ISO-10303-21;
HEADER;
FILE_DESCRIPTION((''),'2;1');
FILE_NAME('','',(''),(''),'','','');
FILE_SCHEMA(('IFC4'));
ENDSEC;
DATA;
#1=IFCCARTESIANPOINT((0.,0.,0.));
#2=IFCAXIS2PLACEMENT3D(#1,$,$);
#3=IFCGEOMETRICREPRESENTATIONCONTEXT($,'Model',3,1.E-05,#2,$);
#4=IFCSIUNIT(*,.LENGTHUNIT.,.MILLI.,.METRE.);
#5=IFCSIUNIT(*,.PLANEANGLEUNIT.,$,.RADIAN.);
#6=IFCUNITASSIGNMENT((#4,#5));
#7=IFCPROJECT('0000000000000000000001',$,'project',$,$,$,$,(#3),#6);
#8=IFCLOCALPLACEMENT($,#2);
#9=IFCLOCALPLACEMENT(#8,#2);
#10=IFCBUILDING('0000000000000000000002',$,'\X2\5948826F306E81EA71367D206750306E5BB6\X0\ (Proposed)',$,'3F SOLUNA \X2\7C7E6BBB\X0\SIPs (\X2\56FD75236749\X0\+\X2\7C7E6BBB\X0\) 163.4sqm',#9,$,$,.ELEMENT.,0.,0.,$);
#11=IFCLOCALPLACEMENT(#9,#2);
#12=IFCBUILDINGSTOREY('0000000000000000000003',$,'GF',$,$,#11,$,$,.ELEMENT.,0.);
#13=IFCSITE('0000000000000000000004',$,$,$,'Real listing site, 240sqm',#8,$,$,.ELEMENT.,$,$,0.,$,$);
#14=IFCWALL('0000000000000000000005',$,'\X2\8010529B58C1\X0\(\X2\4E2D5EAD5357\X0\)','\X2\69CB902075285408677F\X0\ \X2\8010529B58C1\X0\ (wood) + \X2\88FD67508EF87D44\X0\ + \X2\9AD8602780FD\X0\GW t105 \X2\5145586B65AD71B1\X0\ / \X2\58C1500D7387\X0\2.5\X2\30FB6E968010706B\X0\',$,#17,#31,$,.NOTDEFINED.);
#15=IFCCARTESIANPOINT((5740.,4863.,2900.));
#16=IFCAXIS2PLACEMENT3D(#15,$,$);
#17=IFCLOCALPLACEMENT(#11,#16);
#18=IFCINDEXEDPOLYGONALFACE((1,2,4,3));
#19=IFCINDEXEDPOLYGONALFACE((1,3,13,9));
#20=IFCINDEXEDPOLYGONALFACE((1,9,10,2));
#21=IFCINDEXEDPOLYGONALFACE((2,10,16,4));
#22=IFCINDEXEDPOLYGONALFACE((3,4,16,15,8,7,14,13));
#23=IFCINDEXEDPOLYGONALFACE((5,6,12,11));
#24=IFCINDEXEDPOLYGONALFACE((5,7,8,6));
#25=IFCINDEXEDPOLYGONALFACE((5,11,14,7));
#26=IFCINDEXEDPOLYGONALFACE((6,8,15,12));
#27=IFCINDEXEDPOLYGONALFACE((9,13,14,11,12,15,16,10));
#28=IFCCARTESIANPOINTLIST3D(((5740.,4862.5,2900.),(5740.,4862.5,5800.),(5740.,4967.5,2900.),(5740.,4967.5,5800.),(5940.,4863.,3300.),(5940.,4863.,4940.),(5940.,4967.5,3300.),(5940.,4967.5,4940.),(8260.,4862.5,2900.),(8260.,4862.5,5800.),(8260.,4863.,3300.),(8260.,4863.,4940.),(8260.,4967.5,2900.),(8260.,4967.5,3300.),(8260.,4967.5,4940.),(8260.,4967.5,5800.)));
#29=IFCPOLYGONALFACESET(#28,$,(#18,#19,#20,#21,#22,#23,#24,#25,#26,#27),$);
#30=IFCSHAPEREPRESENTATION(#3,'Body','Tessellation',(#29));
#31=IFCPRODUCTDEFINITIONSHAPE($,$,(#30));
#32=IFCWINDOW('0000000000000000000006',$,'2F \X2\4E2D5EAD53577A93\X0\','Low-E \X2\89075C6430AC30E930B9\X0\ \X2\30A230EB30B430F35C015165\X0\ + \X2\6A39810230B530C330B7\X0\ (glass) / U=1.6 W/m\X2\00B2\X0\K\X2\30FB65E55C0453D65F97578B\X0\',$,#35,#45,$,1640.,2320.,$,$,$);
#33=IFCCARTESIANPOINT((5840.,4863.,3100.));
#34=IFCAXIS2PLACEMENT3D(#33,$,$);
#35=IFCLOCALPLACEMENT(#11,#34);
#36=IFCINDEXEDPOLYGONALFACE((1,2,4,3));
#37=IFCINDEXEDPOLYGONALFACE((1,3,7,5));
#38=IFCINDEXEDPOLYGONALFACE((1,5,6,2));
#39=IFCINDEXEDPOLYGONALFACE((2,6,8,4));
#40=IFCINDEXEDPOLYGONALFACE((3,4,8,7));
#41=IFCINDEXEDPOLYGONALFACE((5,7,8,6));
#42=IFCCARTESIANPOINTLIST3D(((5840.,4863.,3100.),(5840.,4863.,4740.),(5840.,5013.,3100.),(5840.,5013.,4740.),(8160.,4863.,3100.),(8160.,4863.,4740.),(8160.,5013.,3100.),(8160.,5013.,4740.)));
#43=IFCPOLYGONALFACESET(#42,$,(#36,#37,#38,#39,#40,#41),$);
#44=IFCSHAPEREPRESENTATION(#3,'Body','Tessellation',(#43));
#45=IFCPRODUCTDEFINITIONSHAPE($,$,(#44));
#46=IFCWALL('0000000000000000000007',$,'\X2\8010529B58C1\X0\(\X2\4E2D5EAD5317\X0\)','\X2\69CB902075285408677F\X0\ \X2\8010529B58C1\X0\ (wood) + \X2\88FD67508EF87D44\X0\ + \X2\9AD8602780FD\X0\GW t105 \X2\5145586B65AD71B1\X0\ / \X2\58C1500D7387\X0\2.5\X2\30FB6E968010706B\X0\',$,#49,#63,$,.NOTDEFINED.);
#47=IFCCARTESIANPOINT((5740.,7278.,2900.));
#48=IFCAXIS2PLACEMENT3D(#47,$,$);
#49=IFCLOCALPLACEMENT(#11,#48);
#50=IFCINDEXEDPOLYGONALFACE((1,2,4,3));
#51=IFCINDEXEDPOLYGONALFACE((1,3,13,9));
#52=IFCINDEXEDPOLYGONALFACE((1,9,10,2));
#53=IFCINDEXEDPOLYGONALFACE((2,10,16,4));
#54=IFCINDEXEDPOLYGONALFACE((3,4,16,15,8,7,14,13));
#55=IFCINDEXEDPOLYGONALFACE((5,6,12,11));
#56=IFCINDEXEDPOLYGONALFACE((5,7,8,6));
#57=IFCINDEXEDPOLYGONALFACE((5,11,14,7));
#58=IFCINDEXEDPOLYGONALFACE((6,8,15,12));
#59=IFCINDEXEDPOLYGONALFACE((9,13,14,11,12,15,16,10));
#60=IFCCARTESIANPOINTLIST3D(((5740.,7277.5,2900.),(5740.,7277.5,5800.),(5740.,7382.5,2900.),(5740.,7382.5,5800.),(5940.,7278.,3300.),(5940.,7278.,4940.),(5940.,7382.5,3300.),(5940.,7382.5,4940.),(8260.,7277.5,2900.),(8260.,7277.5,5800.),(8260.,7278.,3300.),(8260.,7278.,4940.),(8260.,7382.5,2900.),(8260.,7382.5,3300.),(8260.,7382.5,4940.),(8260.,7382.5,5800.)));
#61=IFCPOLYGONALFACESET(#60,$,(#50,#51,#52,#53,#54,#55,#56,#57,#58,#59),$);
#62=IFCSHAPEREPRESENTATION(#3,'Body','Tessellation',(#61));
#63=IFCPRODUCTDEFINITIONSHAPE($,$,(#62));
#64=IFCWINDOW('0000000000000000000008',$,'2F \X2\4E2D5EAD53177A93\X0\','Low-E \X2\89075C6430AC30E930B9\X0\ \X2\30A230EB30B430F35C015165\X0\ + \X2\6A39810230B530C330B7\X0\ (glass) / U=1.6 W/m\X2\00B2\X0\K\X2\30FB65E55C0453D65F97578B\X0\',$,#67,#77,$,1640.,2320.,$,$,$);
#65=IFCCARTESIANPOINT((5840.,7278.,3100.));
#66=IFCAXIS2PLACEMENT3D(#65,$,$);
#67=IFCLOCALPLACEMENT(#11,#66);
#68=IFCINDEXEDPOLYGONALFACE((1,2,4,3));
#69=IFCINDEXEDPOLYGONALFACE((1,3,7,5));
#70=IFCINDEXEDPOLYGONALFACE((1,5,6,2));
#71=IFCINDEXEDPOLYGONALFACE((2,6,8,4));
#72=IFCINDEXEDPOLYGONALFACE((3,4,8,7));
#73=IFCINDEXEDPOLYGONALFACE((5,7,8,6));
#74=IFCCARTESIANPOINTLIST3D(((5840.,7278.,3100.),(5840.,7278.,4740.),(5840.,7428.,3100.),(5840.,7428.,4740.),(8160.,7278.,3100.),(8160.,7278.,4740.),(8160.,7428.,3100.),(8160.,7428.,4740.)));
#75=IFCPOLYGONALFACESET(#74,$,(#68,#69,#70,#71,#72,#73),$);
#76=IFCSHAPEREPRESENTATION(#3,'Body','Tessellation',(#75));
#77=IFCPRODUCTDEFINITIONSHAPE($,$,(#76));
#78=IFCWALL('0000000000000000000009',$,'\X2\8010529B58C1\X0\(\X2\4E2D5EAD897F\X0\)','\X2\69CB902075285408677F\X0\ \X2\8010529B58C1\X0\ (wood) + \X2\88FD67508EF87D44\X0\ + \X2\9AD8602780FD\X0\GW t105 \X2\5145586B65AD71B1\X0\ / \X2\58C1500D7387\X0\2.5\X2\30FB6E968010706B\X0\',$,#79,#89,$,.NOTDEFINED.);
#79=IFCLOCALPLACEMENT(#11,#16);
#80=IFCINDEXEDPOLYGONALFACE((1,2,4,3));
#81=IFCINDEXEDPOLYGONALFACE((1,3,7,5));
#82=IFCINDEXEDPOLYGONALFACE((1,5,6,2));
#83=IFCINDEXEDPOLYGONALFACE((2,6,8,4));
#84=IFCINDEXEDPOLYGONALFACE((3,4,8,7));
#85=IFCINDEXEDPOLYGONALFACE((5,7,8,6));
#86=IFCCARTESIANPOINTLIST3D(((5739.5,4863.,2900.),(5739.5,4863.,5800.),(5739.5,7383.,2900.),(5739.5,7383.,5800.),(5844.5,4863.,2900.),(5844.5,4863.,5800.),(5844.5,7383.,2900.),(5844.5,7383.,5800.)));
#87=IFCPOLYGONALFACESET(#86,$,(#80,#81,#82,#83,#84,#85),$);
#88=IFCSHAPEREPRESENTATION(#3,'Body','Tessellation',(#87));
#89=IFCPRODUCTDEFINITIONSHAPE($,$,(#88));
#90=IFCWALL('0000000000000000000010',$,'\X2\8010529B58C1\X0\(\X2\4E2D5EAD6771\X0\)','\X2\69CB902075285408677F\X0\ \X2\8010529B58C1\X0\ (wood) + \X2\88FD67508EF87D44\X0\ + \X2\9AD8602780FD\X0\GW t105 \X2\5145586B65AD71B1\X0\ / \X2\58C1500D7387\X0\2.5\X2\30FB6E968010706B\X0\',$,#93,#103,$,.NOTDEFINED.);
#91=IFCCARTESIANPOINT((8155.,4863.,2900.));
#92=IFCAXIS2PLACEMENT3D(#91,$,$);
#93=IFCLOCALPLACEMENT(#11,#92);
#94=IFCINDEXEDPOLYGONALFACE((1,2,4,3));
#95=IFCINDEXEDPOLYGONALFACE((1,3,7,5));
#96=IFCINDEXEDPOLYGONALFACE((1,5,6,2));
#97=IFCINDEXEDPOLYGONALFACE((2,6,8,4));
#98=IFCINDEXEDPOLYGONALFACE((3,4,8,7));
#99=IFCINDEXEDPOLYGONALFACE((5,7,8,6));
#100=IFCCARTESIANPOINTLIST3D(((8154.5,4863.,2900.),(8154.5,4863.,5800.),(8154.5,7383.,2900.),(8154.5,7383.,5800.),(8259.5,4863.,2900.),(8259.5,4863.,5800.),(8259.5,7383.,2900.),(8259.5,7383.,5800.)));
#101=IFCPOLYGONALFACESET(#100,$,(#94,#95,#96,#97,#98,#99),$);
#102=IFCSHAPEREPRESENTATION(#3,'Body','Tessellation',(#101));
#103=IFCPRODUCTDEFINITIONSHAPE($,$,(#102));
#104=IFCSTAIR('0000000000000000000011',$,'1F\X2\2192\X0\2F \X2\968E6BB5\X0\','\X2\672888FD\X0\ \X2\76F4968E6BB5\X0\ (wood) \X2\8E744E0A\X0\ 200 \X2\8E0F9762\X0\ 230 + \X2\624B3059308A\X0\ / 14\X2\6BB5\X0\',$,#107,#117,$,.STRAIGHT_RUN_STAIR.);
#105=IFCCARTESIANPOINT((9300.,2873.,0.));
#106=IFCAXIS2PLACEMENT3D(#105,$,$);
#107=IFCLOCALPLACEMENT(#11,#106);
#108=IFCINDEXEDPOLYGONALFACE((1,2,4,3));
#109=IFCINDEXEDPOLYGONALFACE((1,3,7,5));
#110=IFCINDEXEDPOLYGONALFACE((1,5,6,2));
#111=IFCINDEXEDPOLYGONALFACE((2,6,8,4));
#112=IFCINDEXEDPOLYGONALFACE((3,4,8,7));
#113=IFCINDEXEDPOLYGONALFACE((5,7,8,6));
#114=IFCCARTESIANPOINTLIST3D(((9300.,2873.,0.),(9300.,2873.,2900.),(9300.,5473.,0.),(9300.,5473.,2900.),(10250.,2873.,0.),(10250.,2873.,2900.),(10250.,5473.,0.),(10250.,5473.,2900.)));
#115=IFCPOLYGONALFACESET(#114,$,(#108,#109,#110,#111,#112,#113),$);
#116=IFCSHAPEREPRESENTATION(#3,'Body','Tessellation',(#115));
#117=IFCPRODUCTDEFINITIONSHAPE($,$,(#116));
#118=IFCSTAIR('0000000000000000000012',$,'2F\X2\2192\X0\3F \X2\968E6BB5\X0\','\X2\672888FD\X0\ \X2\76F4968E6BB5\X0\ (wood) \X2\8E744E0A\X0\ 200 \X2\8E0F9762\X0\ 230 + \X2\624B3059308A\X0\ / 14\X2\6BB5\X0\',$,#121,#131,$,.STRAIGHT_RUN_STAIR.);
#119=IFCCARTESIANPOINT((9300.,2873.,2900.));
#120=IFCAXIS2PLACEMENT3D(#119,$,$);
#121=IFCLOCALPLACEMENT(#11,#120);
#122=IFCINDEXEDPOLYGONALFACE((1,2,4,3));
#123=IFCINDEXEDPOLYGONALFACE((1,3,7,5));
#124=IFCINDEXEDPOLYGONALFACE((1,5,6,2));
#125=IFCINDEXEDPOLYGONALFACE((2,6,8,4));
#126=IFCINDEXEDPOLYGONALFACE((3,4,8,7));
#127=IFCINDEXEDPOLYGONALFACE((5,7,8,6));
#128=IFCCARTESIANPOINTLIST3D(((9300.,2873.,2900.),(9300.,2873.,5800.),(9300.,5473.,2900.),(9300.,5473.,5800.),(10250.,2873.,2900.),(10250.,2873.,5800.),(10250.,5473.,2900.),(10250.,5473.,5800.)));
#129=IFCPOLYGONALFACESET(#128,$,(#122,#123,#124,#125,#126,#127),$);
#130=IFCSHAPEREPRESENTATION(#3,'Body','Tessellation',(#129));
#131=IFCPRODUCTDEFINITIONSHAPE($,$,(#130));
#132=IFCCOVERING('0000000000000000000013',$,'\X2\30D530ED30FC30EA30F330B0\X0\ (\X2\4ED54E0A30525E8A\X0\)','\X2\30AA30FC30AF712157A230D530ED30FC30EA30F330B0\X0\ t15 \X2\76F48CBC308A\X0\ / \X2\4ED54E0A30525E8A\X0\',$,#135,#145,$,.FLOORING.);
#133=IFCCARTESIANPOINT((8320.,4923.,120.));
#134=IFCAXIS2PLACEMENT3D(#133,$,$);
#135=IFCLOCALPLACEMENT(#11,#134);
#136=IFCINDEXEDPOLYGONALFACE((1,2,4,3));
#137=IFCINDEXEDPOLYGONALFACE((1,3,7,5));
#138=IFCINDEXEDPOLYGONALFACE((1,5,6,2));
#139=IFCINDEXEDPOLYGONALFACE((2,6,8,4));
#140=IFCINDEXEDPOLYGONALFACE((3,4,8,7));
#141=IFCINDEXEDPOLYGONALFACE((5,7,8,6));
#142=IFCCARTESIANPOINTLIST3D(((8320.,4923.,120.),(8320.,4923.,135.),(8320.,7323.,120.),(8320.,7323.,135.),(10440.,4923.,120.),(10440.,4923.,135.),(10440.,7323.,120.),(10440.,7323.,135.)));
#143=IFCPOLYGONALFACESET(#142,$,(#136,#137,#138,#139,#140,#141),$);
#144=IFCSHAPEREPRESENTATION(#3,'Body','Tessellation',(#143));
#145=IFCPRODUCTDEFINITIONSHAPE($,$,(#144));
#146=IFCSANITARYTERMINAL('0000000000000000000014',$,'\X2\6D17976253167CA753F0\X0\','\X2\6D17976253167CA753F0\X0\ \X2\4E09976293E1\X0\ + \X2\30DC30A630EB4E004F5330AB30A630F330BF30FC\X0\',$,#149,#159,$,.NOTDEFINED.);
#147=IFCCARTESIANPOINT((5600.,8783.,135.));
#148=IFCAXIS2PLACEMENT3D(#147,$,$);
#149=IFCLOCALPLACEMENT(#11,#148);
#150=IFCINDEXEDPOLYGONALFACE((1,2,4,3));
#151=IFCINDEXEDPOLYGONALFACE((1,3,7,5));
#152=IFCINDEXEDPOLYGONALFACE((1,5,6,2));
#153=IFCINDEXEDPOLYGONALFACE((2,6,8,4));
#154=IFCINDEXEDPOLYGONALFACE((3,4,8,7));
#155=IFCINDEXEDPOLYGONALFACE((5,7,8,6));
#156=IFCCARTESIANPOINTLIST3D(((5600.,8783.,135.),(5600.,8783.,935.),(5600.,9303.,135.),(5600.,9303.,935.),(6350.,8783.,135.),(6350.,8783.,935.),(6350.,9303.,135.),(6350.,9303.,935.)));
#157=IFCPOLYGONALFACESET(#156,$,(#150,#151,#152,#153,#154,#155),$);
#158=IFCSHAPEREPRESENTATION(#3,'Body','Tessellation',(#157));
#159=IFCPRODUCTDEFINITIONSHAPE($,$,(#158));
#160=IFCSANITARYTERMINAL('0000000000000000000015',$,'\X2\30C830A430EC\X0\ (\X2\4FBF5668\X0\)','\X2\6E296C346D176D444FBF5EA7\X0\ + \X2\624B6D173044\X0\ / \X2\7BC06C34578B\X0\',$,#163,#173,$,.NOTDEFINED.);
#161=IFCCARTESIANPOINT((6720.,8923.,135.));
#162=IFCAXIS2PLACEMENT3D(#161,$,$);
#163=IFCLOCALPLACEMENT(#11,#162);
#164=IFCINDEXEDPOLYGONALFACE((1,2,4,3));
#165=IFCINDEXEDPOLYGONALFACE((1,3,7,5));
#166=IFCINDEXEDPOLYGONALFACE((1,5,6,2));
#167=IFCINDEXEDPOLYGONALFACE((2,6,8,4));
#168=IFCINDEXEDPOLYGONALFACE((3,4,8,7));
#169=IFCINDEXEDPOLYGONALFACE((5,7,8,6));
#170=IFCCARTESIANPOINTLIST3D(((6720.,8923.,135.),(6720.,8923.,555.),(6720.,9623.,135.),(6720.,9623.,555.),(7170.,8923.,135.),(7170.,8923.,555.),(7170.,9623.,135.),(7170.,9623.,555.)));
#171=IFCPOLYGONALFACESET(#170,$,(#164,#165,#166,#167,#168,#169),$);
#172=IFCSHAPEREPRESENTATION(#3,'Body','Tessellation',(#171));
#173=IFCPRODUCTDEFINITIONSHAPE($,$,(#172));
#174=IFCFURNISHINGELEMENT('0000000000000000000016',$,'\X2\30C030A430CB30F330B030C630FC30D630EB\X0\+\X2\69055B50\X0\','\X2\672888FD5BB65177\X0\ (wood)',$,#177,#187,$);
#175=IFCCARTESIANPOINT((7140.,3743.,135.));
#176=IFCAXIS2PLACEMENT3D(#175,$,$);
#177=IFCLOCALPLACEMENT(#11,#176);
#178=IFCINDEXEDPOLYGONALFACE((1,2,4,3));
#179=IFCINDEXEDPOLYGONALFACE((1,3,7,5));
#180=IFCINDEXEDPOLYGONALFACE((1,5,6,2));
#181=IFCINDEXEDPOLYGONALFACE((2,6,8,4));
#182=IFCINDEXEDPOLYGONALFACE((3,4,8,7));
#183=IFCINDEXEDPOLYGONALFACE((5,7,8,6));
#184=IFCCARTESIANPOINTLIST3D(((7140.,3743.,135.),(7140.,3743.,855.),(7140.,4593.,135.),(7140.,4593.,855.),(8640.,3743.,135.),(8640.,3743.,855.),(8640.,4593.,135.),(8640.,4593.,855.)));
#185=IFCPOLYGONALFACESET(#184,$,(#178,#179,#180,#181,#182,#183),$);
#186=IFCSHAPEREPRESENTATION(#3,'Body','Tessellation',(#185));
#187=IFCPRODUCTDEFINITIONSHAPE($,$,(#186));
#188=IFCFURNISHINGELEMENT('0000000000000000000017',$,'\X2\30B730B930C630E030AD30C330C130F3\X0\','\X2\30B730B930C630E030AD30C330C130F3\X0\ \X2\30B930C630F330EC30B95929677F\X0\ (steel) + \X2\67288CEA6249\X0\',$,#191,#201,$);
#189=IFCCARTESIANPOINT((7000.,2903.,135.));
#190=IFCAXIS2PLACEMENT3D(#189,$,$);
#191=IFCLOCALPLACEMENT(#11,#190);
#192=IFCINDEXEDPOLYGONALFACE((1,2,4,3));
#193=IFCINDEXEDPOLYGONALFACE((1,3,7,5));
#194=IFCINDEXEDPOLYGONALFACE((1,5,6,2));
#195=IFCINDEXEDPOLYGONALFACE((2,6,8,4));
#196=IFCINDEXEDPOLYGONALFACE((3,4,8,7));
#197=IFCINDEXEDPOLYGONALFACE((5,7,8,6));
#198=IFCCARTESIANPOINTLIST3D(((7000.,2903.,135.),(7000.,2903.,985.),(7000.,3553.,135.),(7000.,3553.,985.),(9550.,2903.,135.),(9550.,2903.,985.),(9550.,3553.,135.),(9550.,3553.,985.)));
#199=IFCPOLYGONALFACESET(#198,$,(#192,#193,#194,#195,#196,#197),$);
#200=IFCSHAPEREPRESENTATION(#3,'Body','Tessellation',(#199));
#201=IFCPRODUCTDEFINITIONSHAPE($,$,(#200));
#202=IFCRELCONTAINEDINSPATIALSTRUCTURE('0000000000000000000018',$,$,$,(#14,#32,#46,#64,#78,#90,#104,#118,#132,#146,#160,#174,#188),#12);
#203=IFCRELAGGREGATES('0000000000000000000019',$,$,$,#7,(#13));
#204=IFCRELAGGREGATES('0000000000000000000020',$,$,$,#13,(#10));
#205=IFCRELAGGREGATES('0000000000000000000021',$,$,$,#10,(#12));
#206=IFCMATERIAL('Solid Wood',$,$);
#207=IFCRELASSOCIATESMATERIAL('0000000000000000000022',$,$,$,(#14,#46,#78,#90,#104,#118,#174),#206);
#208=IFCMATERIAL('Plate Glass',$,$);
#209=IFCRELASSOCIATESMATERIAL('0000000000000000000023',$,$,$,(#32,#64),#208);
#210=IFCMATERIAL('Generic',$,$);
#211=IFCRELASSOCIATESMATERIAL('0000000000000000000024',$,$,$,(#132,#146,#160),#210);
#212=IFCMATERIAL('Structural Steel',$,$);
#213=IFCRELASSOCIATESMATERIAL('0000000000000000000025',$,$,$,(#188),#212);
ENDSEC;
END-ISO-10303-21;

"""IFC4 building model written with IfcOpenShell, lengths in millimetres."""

from ifc_helpers import new_model, si_unit, frame, frame_2d, origin, place, context, project, spatial, rectangle, extrude, material, element, fill, save


model = new_model("IFC4")

# Units and contexts
model_context = context("Model", 3, precision=1e-05, world=origin())
ifc_project = project(units=[si_unit("LENGTHUNIT", "METRE", prefix="MILLI"), si_unit("PLANEANGLEUNIT", "RADIAN")], contexts=[model_context])

# Site, building, storey
site_placement = place(None, origin())
site = spatial("IfcSite", under=ifc_project, at=site_placement, ObjectType="Real listing site, 240sqm", CompositionType="ELEMENT", RefElevation=0.0)
building_placement = place(site_placement, origin())
building = spatial("IfcBuilding", under=site, at=building_placement, Name="奈良の自然素材の家 (Proposed)", ObjectType="3F SOLUNA 籾殻SIPs (国産杉+籾殻) 163.4sqm", CompositionType="ELEMENT", ElevationOfRefHeight=0.0, ElevationOfTerrain=0.0)
storey_placement = place(building_placement, origin())
storey = spatial("IfcBuildingStorey", under=building, at=storey_placement, Name="GF", CompositionType="ELEMENT", Elevation=0.0)

# Shared definitions
ifc_material_1 = material(Name="Solid Wood")

# Shared definitions
ifc_material_2 = material(Name="Plate Glass")

# Walls, openings, windows
wall_1_placement = place(storey_placement, frame((5740.0, 4863.0, 2900.0)))
wall_1 = element("IfcWall", 1, at=wall_1_placement, inside=storey, material=ifc_material_1, Name="耐力壁(中庭南)", Description="構造用合板 耐力壁 (wood) + 製材軸組 + 高性能GW t105 充填断熱 / 壁倍率2.5・準耐火", PredefinedType="NOTDEFINED", context=model_context, shape_type="SweptSolid", body=[
    extrude(rectangle(XDim=2520.0, YDim=105.0, at=frame_2d((1260.0, 52.0))), frame((5740.0, 4863.0, 2900.0)), (0.0, 0.0, 1.0), 2900.0),
])
opening_1_placement = place(storey_placement, frame((5840.0, 4863.0, 3100.0)))
opening_1 = element("IfcOpeningElement", 2, at=opening_1_placement, cuts=wall_1, PredefinedType="NOTDEFINED", context=model_context, shape_type="SweptSolid", body=[
    extrude(rectangle(XDim=2320.0, YDim=150.0, at=frame_2d((1160.0, 75.0))), frame((5840.0, 4863.0, 3100.0)), (0.0, 0.0, 1.0), 1640.0),
])
window_1_placement = place(storey_placement, frame((5840.0, 4863.0, 3100.0)))
window_1 = element("IfcWindow", 3, at=window_1_placement, inside=storey, material=ifc_material_2, Name="2F 中庭南窓", Description="Low-E 複層ガラス アルゴン封入 + 樹脂サッシ (glass) / U=1.6 W/m²K・日射取得型", OverallHeight=1640.0, OverallWidth=2320.0, context=model_context, shape_type="SweptSolid", body=[
    extrude(rectangle(XDim=2320.0, YDim=150.0, at=frame_2d((1160.0, 75.0))), frame((5840.0, 4863.0, 3100.0)), (0.0, 0.0, 1.0), 1640.0),
])
fill(opening_1, window_1)
wall_2_placement = place(storey_placement, frame((5740.0, 7278.0, 2900.0)))
wall_2 = element("IfcWall", 4, at=wall_2_placement, inside=storey, material=ifc_material_1, Name="耐力壁(中庭北)", Description="構造用合板 耐力壁 (wood) + 製材軸組 + 高性能GW t105 充填断熱 / 壁倍率2.5・準耐火", PredefinedType="NOTDEFINED", context=model_context, shape_type="SweptSolid", body=[
    extrude(rectangle(XDim=2520.0, YDim=105.0, at=frame_2d((1260.0, 52.0))), frame((5740.0, 7278.0, 2900.0)), (0.0, 0.0, 1.0), 2900.0),
])
opening_2_placement = place(storey_placement, frame((5840.0, 7278.0, 3100.0)))
opening_2 = element("IfcOpeningElement", 5, at=opening_2_placement, cuts=wall_2, PredefinedType="NOTDEFINED", context=model_context, shape_type="SweptSolid", body=[
    extrude(rectangle(XDim=2320.0, YDim=150.0, at=frame_2d((1160.0, 75.0))), frame((5840.0, 7278.0, 3100.0)), (0.0, 0.0, 1.0), 1640.0),
])
window_2_placement = place(storey_placement, frame((5840.0, 7278.0, 3100.0)))
window_2 = element("IfcWindow", 6, at=window_2_placement, inside=storey, material=ifc_material_2, Name="2F 中庭北窓", Description="Low-E 複層ガラス アルゴン封入 + 樹脂サッシ (glass) / U=1.6 W/m²K・日射取得型", OverallHeight=1640.0, OverallWidth=2320.0, context=model_context, shape_type="SweptSolid", body=[
    extrude(rectangle(XDim=2320.0, YDim=150.0, at=frame_2d((1160.0, 75.0))), frame((5840.0, 7278.0, 3100.0)), (0.0, 0.0, 1.0), 1640.0),
])
fill(opening_2, window_2)

# Walls
wall_3_placement = place(storey_placement, frame((5740.0, 4863.0, 2900.0)))
element("IfcWall", 7, at=wall_3_placement, inside=storey, material=ifc_material_1, Name="耐力壁(中庭西)", Description="構造用合板 耐力壁 (wood) + 製材軸組 + 高性能GW t105 充填断熱 / 壁倍率2.5・準耐火", PredefinedType="NOTDEFINED", context=model_context, shape_type="SweptSolid", body=[
    extrude(rectangle(XDim=105.0, YDim=2520.0, at=frame_2d((52.0, 1260.0))), frame((5740.0, 4863.0, 2900.0)), (0.0, 0.0, 1.0), 2900.0),
])
wall_4_placement = place(storey_placement, frame((8155.0, 4863.0, 2900.0)))
element("IfcWall", 8, at=wall_4_placement, inside=storey, material=ifc_material_1, Name="耐力壁(中庭東)", Description="構造用合板 耐力壁 (wood) + 製材軸組 + 高性能GW t105 充填断熱 / 壁倍率2.5・準耐火", PredefinedType="NOTDEFINED", context=model_context, shape_type="SweptSolid", body=[
    extrude(rectangle(XDim=105.0, YDim=2520.0, at=frame_2d((52.0, 1260.0))), frame((8155.0, 4863.0, 2900.0)), (0.0, 0.0, 1.0), 2900.0),
])

# Stairs
stair_1_placement = place(storey_placement, frame((9300.0, 2873.0, 0.0)))
element("IfcStair", 9, at=stair_1_placement, inside=storey, material=ifc_material_1, Name="1F→2F 階段", Description="木製 直階段 (wood) 蹴上 200 踏面 230 + 手すり / 14段", PredefinedType="STRAIGHT_RUN_STAIR", context=model_context, shape_type="SweptSolid", body=[
    extrude(rectangle(XDim=950.0, YDim=2600.0, at=frame_2d((475.0, 1300.0))), frame((9300.0, 2873.0, 0.0)), (0.0, 0.0, 1.0), 2900.0),
])
stair_2_placement = place(storey_placement, frame((9300.0, 2873.0, 2900.0)))
element("IfcStair", 10, at=stair_2_placement, inside=storey, material=ifc_material_1, Name="2F→3F 階段", Description="木製 直階段 (wood) 蹴上 200 踏面 230 + 手すり / 14段", PredefinedType="STRAIGHT_RUN_STAIR", context=model_context, shape_type="SweptSolid", body=[
    extrude(rectangle(XDim=950.0, YDim=2600.0, at=frame_2d((475.0, 1300.0))), frame((9300.0, 2873.0, 2900.0)), (0.0, 0.0, 1.0), 2900.0),
])

# Covering
ifc_material_3 = material(Name="Generic")
covering_placement = place(storey_placement, frame((8320.0, 4923.0, 120.0)))
element("IfcCovering", 11, at=covering_placement, inside=storey, material=ifc_material_3, Name="フローリング (仕上げ床)", Description="オーク無垢フローリング t15 直貼り / 仕上げ床", PredefinedType="FLOORING", context=model_context, shape_type="SweptSolid", body=[
    extrude(rectangle(XDim=2120.0, YDim=2400.0, at=frame_2d((1060.0, 1200.0))), frame((8320.0, 4923.0, 120.0)), (0.0, 0.0, 1.0), 15.0),
])

# Sanitary terminals
sanitary_terminal_1_placement = place(storey_placement, frame((5600.0, 8783.0, 135.0)))
element("IfcSanitaryTerminal", 12, at=sanitary_terminal_1_placement, inside=storey, material=ifc_material_3, Name="洗面化粧台", Description="洗面化粧台 三面鏡 + ボウル一体カウンター", PredefinedType="NOTDEFINED", context=model_context, shape_type="SweptSolid", body=[
    extrude(rectangle(XDim=750.0, YDim=520.0, at=frame_2d((375.0, 260.0))), frame((5600.0, 8783.0, 135.0)), (0.0, 0.0, 1.0), 800.0),
])
sanitary_terminal_2_placement = place(storey_placement, frame((6720.0, 8923.0, 135.0)))
element("IfcSanitaryTerminal", 13, at=sanitary_terminal_2_placement, inside=storey, material=ifc_material_3, Name="トイレ (便器)", Description="温水洗浄便座 + 手洗い / 節水型", PredefinedType="NOTDEFINED", context=model_context, shape_type="SweptSolid", body=[
    extrude(rectangle(XDim=450.0, YDim=700.0, at=frame_2d((225.0, 350.0))), frame((6720.0, 8923.0, 135.0)), (0.0, 0.0, 1.0), 420.0),
])

# Furnishing elements
furnishing_1_placement = place(storey_placement, frame((7140.0, 3743.0, 135.0)))
element("IfcFurnishingElement", 14, at=furnishing_1_placement, inside=storey, material=ifc_material_1, Name="ダイニングテーブル+椅子", Description="木製家具 (wood)", context=model_context, shape_type="SweptSolid", body=[
    extrude(rectangle(XDim=1500.0, YDim=850.0, at=frame_2d((750.0, 425.0))), frame((7140.0, 3743.0, 135.0)), (0.0, 0.0, 1.0), 720.0),
])
ifc_material_4 = material(Name="Structural Steel")
furnishing_2_placement = place(storey_placement, frame((7000.0, 2903.0, 135.0)))
element("IfcFurnishingElement", 15, at=furnishing_2_placement, inside=storey, material=ifc_material_4, Name="システムキッチン", Description="システムキッチン ステンレス天板 (steel) + 木質扉", context=model_context, shape_type="SweptSolid", body=[
    extrude(rectangle(XDim=2550.0, YDim=650.0, at=frame_2d((1275.0, 325.0))), frame((7000.0, 2903.0, 135.0)), (0.0, 0.0, 1.0), 850.0),
])

save(model, "model.ifc")
